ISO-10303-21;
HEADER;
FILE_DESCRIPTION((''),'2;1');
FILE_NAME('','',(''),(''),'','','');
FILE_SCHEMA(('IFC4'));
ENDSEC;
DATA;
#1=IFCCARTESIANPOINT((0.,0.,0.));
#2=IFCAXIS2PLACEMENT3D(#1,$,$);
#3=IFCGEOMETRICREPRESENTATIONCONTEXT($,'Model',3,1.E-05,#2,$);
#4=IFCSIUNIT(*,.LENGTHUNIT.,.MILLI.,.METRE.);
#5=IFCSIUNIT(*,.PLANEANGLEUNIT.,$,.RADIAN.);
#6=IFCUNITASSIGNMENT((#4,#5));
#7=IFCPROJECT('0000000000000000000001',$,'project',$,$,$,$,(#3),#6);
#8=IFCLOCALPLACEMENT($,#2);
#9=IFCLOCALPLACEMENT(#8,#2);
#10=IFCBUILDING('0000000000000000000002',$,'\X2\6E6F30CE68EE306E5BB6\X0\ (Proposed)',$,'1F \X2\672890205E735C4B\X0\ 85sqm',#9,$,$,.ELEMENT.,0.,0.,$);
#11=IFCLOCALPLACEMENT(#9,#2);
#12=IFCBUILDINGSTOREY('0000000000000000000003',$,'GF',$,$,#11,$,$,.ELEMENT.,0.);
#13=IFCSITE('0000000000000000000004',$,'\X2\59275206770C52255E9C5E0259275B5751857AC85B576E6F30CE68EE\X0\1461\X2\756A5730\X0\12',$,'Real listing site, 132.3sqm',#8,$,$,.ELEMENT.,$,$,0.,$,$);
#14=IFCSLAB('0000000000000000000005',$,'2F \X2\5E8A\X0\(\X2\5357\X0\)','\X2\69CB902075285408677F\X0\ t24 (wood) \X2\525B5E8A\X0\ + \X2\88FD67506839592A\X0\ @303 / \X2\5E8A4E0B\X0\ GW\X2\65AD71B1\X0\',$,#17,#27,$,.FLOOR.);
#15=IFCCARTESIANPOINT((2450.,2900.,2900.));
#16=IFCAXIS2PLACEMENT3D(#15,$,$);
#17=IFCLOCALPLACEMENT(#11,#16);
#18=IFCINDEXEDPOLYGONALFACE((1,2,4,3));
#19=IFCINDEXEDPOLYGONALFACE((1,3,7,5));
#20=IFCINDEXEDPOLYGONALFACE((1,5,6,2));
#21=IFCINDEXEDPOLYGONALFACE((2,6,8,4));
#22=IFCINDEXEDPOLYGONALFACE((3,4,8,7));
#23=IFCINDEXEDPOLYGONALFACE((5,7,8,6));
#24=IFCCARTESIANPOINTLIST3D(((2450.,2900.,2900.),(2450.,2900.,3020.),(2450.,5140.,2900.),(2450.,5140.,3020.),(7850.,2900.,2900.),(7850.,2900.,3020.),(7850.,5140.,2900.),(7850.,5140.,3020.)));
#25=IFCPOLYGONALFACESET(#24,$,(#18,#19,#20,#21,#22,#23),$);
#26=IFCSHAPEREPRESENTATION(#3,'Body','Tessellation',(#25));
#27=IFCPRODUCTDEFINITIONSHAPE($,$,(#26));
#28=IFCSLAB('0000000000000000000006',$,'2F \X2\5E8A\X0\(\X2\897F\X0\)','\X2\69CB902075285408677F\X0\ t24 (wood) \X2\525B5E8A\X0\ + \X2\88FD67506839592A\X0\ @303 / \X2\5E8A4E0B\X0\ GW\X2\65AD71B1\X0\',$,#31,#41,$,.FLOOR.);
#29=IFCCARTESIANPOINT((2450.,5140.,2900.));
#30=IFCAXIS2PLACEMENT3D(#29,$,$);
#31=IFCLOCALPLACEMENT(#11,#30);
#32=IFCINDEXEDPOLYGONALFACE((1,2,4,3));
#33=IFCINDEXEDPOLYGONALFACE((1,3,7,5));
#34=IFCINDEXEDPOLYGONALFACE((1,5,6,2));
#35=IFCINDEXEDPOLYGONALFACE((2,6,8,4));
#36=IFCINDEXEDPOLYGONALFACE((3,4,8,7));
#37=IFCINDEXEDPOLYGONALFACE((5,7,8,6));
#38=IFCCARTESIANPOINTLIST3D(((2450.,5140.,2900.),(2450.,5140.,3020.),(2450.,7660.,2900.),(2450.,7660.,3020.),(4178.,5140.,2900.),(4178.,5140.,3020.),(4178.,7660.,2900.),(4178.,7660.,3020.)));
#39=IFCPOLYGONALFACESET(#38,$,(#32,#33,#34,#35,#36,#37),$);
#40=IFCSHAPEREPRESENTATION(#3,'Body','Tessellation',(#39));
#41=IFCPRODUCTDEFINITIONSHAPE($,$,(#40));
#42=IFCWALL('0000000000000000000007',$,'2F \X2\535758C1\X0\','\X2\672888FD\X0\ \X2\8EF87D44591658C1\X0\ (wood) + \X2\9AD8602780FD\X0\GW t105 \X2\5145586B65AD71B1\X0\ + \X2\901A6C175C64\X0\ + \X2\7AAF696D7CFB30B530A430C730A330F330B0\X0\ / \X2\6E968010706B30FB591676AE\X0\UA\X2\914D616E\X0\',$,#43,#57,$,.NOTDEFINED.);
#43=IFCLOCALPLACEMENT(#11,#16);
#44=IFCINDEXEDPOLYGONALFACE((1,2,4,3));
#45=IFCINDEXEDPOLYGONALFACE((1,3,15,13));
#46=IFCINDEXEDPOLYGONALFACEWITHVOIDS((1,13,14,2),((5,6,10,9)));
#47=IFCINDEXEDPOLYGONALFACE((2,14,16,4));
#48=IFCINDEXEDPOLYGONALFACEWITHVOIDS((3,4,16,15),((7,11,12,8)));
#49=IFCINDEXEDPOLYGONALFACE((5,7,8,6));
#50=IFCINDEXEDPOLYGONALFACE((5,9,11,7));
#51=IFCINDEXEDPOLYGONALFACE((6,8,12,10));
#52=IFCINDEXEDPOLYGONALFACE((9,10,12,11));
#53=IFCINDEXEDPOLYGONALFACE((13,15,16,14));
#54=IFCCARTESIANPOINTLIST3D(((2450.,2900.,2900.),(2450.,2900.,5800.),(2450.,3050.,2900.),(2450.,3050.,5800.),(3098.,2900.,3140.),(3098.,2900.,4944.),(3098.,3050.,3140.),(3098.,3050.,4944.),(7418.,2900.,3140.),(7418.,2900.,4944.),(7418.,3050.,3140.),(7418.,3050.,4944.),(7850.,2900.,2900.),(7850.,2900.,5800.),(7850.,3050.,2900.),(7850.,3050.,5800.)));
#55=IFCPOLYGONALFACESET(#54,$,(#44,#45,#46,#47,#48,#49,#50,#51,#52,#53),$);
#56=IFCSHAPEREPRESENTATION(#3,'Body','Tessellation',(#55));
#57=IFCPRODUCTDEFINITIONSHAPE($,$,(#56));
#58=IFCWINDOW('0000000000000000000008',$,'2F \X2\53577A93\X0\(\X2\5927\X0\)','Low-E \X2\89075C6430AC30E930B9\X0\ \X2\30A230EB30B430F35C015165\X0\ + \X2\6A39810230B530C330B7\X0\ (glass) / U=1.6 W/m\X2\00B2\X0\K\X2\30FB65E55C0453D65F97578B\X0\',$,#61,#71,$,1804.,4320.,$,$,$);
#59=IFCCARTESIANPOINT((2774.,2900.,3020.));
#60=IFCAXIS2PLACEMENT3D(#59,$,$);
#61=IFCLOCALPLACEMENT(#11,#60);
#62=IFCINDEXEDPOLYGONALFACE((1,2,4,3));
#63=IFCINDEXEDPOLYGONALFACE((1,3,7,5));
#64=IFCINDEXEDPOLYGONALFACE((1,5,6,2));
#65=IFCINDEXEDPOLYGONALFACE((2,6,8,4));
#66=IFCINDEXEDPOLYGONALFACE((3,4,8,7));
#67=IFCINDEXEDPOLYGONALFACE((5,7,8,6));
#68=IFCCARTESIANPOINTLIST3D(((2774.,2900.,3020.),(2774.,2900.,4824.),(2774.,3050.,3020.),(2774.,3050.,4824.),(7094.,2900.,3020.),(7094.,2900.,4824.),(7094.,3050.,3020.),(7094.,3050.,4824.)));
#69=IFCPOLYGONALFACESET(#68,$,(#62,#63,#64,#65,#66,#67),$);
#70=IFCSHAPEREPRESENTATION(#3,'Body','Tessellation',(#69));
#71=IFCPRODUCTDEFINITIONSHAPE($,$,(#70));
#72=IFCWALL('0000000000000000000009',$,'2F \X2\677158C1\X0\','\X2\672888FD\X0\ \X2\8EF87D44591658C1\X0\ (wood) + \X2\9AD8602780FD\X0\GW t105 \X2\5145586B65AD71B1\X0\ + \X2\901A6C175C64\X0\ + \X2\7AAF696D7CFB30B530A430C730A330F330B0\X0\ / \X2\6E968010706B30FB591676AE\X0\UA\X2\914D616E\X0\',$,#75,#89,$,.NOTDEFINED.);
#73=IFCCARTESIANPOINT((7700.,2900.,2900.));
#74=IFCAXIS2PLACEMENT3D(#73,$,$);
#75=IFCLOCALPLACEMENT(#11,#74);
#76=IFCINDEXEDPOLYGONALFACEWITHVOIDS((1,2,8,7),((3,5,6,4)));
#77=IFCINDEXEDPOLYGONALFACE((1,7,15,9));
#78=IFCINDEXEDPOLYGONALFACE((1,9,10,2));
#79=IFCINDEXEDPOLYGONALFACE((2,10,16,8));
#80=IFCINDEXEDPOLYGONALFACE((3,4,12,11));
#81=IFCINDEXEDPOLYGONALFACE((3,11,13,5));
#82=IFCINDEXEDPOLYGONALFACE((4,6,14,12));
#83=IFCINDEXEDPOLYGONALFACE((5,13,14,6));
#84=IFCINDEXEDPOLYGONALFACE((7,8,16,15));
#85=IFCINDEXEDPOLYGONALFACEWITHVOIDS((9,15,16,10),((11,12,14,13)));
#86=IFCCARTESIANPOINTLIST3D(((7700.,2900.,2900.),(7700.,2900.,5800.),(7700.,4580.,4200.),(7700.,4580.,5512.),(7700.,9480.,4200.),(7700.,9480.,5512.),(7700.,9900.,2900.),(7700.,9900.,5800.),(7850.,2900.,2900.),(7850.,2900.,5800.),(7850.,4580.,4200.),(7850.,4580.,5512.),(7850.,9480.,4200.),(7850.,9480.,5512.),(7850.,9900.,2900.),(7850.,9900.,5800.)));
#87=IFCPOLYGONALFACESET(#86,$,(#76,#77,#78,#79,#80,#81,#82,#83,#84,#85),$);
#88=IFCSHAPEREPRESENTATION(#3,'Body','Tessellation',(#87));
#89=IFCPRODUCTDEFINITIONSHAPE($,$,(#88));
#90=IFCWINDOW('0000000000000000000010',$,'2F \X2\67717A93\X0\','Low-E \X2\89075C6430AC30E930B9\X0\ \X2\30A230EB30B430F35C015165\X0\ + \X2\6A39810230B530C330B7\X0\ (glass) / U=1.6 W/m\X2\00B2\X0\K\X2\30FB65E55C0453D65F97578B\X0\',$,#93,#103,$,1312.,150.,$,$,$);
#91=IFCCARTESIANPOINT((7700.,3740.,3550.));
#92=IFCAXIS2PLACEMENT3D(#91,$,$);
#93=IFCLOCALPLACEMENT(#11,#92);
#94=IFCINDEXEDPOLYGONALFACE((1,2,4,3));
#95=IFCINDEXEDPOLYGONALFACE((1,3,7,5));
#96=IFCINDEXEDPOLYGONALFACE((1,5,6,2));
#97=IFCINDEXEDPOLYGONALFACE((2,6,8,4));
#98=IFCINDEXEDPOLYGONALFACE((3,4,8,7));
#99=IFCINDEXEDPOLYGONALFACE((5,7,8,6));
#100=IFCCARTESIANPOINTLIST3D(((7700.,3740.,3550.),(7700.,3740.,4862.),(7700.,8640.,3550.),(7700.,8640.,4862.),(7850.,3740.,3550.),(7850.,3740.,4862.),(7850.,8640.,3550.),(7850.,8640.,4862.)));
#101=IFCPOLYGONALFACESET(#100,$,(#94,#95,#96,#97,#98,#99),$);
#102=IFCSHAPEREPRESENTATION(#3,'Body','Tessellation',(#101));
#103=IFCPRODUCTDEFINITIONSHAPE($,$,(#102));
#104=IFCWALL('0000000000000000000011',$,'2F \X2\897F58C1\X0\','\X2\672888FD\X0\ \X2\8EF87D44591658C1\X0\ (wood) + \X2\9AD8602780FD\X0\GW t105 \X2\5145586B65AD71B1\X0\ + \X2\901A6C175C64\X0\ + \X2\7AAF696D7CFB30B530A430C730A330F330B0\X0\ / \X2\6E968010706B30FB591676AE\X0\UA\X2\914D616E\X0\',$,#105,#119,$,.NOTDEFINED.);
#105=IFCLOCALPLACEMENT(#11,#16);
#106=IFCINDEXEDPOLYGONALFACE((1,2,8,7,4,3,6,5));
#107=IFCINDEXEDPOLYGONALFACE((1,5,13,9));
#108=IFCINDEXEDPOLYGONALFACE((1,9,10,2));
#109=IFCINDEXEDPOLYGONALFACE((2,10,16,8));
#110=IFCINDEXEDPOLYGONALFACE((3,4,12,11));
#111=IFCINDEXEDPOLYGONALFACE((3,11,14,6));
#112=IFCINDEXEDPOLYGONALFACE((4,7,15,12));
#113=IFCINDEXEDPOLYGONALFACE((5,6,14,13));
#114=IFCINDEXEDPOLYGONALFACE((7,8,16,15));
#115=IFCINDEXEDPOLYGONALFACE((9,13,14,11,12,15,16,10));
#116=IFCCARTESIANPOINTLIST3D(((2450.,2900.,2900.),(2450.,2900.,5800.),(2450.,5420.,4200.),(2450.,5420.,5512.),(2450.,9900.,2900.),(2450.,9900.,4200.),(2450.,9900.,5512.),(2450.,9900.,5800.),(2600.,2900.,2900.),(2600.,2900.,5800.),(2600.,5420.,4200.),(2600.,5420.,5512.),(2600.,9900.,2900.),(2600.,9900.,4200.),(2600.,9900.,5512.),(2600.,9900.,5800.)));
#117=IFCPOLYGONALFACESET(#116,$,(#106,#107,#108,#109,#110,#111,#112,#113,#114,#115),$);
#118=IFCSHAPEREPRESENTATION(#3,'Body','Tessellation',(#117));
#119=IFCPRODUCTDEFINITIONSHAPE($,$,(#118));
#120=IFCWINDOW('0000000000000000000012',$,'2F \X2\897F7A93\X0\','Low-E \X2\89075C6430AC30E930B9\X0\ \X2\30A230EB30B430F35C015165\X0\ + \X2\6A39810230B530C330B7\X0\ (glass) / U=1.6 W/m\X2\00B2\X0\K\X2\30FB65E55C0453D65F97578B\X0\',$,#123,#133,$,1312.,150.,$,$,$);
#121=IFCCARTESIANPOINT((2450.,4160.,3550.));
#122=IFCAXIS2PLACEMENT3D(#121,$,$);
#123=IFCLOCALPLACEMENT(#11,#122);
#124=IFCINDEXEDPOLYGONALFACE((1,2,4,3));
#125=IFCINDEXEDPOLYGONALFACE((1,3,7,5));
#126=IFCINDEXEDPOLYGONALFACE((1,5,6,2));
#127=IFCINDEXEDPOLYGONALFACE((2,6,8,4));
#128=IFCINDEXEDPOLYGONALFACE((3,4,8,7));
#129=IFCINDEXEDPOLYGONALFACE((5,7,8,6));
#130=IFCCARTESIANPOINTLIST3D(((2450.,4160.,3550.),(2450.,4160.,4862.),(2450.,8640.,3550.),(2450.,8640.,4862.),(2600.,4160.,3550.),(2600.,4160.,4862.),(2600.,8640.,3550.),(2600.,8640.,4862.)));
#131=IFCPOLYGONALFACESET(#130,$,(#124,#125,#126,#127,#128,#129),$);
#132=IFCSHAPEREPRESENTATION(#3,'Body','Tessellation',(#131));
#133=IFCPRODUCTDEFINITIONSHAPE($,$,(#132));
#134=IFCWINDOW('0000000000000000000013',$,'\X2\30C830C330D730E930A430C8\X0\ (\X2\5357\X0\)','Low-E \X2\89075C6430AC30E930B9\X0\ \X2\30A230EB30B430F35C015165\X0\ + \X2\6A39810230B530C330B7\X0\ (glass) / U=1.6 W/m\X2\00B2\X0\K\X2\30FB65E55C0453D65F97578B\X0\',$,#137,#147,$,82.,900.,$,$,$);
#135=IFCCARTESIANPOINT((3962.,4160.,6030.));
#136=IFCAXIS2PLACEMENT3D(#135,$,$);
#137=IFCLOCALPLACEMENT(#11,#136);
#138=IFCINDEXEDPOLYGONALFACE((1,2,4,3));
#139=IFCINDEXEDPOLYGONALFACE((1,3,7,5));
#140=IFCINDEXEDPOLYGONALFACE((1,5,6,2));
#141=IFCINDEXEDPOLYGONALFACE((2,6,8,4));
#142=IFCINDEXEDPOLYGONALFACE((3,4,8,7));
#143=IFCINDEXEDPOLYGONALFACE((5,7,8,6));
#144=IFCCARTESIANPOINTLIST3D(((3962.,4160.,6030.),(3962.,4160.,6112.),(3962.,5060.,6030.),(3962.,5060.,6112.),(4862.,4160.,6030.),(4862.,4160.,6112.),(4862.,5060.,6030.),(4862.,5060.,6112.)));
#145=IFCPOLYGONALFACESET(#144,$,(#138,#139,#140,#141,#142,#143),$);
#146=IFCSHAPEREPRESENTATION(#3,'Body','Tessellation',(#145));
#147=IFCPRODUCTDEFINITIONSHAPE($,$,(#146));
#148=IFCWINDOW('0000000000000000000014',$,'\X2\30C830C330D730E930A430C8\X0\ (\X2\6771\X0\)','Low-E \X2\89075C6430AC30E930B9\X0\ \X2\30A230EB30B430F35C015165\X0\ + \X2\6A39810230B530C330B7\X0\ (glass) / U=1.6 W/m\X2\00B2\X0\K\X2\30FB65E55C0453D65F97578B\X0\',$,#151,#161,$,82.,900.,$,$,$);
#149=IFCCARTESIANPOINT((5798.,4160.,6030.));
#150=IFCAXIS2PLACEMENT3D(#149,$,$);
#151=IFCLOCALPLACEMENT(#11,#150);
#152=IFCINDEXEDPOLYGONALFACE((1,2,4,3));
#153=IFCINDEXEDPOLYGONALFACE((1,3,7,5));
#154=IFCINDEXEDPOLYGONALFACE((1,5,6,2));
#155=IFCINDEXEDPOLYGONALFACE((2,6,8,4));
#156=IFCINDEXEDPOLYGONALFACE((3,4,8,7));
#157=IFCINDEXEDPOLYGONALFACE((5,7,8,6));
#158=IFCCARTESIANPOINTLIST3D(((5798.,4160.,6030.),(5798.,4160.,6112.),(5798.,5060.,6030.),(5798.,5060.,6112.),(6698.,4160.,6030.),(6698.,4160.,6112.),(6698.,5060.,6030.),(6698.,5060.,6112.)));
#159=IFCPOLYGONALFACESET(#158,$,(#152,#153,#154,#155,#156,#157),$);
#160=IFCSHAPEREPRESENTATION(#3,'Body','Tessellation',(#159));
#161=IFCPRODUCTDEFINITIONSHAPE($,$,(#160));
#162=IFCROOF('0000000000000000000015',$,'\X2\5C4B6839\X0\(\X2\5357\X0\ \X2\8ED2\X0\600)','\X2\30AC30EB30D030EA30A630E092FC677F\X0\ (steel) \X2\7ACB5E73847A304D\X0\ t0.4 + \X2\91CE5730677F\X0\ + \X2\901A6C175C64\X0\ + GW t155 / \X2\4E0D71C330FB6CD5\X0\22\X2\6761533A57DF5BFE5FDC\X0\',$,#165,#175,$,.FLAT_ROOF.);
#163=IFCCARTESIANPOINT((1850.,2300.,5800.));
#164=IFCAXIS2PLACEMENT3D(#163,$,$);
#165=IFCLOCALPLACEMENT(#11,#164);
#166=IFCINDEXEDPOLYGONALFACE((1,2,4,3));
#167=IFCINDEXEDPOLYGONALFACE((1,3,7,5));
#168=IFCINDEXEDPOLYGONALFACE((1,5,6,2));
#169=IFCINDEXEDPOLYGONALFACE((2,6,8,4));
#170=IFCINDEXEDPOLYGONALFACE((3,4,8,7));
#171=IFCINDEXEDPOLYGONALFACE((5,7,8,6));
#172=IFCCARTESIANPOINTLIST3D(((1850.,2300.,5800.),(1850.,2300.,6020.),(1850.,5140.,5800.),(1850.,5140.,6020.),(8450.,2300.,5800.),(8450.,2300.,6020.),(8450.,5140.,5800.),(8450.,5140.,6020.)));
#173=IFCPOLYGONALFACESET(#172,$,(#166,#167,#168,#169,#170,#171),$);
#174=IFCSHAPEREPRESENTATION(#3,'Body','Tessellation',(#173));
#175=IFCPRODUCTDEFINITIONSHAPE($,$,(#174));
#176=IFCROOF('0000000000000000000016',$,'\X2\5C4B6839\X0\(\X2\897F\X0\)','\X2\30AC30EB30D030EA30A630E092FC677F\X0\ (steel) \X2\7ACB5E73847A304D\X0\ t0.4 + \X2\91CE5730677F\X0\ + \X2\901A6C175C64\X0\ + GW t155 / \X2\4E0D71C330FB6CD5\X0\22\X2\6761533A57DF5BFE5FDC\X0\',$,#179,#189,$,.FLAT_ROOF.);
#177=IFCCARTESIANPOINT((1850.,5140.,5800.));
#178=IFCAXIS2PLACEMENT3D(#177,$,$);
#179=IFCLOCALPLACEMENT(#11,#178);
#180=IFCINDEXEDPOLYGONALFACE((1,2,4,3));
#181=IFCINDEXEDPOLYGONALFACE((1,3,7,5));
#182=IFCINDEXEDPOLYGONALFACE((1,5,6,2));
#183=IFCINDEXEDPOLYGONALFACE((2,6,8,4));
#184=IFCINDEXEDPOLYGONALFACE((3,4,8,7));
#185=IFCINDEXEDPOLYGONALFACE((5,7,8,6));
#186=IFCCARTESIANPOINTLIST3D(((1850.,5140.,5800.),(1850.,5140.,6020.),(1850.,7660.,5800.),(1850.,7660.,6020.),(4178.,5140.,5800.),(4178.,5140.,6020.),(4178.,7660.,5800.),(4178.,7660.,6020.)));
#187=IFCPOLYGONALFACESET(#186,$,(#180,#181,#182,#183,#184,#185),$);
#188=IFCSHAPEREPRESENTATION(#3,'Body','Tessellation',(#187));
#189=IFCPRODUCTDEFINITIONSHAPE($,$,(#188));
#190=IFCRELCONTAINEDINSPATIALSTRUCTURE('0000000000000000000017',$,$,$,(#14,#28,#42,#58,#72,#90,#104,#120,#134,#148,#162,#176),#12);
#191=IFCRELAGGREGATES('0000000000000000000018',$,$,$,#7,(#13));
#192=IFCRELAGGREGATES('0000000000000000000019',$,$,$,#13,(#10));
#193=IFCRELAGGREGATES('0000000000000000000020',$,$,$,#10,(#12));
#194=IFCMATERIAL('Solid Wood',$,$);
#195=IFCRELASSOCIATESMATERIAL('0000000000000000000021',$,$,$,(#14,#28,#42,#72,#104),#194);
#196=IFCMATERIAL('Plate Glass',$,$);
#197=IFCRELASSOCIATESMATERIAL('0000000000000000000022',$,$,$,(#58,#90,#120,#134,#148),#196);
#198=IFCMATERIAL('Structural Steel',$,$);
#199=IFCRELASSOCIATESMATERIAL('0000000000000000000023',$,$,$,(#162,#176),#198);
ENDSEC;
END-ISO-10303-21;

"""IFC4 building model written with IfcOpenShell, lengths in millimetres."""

from ifc_helpers import new_model, si_unit, frame, frame_2d, origin, place, context, project, spatial, rectangle, extrude, material, element, fill, save


model = new_model("IFC4")

# Units and contexts
model_context = context("Model", 3, precision=1e-05, world=origin())
ifc_project = project(units=[si_unit("LENGTHUNIT", "METRE", prefix="MILLI"), si_unit("PLANEANGLEUNIT", "RADIAN")], contexts=[model_context])

# Site, building, storey
site_placement = place(None, origin())
site = spatial("IfcSite", under=ifc_project, at=site_placement, Name="大分県別府市大字内竈字湯ノ森1461番地12", ObjectType="Real listing site, 132.3sqm", CompositionType="ELEMENT", RefElevation=0.0)
building_placement = place(site_placement, origin())
building = spatial("IfcBuilding", under=site, at=building_placement, Name="湯ノ森の家 (Proposed)", ObjectType="1F 木造平屋 85sqm", CompositionType="ELEMENT", ElevationOfRefHeight=0.0, ElevationOfTerrain=0.0)
storey_placement = place(building_placement, origin())
storey = spatial("IfcBuildingStorey", under=building, at=storey_placement, Name="GF", CompositionType="ELEMENT", Elevation=0.0)

# Slabs
ifc_material_1 = material(Name="Solid Wood")
slab_1_placement = place(storey_placement, frame((2450.0, 2900.0, 2900.0)))
element("IfcSlab", 1, at=slab_1_placement, inside=storey, material=ifc_material_1, Name="2F 床(南)", Description="構造用合板 t24 (wood) 剛床 + 製材根太 @303 / 床下 GW断熱", PredefinedType="FLOOR", context=model_context, shape_type="SweptSolid", body=[
    extrude(rectangle(XDim=5400.0, YDim=2240.0, at=frame_2d((2700.0, 1120.0))), frame((2450.0, 2900.0, 2900.0)), (0.0, 0.0, 1.0), 120.0),
])
slab_2_placement = place(storey_placement, frame((2450.0, 5140.0, 2900.0)))
element("IfcSlab", 2, at=slab_2_placement, inside=storey, material=ifc_material_1, Name="2F 床(西)", Description="構造用合板 t24 (wood) 剛床 + 製材根太 @303 / 床下 GW断熱", PredefinedType="FLOOR", context=model_context, shape_type="SweptSolid", body=[
    extrude(rectangle(XDim=1728.0, YDim=2520.0, at=frame_2d((864.0, 1260.0))), frame((2450.0, 5140.0, 2900.0)), (0.0, 0.0, 1.0), 120.0),
])

# Walls, openings, windows
wall_1_placement = place(storey_placement, frame((2450.0, 2900.0, 2900.0)))
wall_1 = element("IfcWall", 3, at=wall_1_placement, inside=storey, material=ifc_material_1, Name="2F 南壁", Description="木製 軸組外壁 (wood) + 高性能GW t105 充填断熱 + 通気層 + 窯業系サイディング / 準耐火・外皮UA配慮", PredefinedType="NOTDEFINED", context=model_context, shape_type="SweptSolid", body=[
    extrude(rectangle(XDim=5400.0, YDim=150.0, at=frame_2d((2700.0, 75.0))), frame((2450.0, 2900.0, 2900.0)), (0.0, 0.0, 1.0), 2900.0),
])
opening_1_placement = place(storey_placement, frame((2774.0, 2900.0, 3020.0)))
opening_1 = element("IfcOpeningElement", 4, at=opening_1_placement, cuts=wall_1, PredefinedType="NOTDEFINED", context=model_context, shape_type="SweptSolid", body=[
    extrude(rectangle(XDim=4320.0, YDim=150.0, at=frame_2d((2160.0, 75.0))), frame((2774.0, 2900.0, 3020.0)), (0.0, 0.0, 1.0), 1804.0),
])
ifc_material_2 = material(Name="Plate Glass")
window_1_placement = place(storey_placement, frame((2774.0, 2900.0, 3020.0)))
window_1 = element("IfcWindow", 5, at=window_1_placement, inside=storey, material=ifc_material_2, Name="2F 南窓(大)", Description="Low-E 複層ガラス アルゴン封入 + 樹脂サッシ (glass) / U=1.6 W/m²K・日射取得型", OverallHeight=1804.0, OverallWidth=4320.0, context=model_context, shape_type="SweptSolid", body=[
    extrude(rectangle(XDim=4320.0, YDim=150.0, at=frame_2d((2160.0, 75.0))), frame((2774.0, 2900.0, 3020.0)), (0.0, 0.0, 1.0), 1804.0),
])
fill(opening_1, window_1)
wall_2_placement = place(storey_placement, frame((7700.0, 2900.0, 2900.0)))
wall_2 = element("IfcWall", 6, at=wall_2_placement, inside=storey, material=ifc_material_1, Name="2F 東壁", Description="木製 軸組外壁 (wood) + 高性能GW t105 充填断熱 + 通気層 + 窯業系サイディング / 準耐火・外皮UA配慮", PredefinedType="NOTDEFINED", context=model_context, shape_type="SweptSolid", body=[
    extrude(rectangle(XDim=150.0, YDim=7000.0, at=frame_2d((75.0, 3500.0))), frame((7700.0, 2900.0, 2900.0)), (0.0, 0.0, 1.0), 2900.0),
])
opening_2_placement = place(storey_placement, frame((7700.0, 3740.0, 3550.0)))
opening_2 = element("IfcOpeningElement", 7, at=opening_2_placement, cuts=wall_2, PredefinedType="NOTDEFINED", context=model_context, shape_type="SweptSolid", body=[
    extrude(rectangle(XDim=150.0, YDim=4900.0, at=frame_2d((75.0, 2450.0))), frame((7700.0, 3740.0, 3550.0)), (0.0, 0.0, 1.0), 1312.0),
])
window_2_placement = place(storey_placement, frame((7700.0, 3740.0, 3550.0)))
window_2 = element("IfcWindow", 8, at=window_2_placement, inside=storey, material=ifc_material_2, Name="2F 東窓", Description="Low-E 複層ガラス アルゴン封入 + 樹脂サッシ (glass) / U=1.6 W/m²K・日射取得型", OverallHeight=1312.0, OverallWidth=150.0, context=model_context, shape_type="SweptSolid", body=[
    extrude(rectangle(XDim=150.0, YDim=4900.0, at=frame_2d((75.0, 2450.0))), frame((7700.0, 3740.0, 3550.0)), (0.0, 0.0, 1.0), 1312.0),
])
fill(opening_2, window_2)
wall_3_placement = place(storey_placement, frame((2450.0, 2900.0, 2900.0)))
wall_3 = element("IfcWall", 9, at=wall_3_placement, inside=storey, material=ifc_material_1, Name="2F 西壁", Description="木製 軸組外壁 (wood) + 高性能GW t105 充填断熱 + 通気層 + 窯業系サイディング / 準耐火・外皮UA配慮", PredefinedType="NOTDEFINED", context=model_context, shape_type="SweptSolid", body=[
    extrude(rectangle(XDim=150.0, YDim=7000.0, at=frame_2d((75.0, 3500.0))), frame((2450.0, 2900.0, 2900.0)), (0.0, 0.0, 1.0), 2900.0),
])
opening_3_placement = place(storey_placement, frame((2450.0, 4160.0, 3550.0)))
opening_3 = element("IfcOpeningElement", 10, at=opening_3_placement, cuts=wall_3, PredefinedType="NOTDEFINED", context=model_context, shape_type="SweptSolid", body=[
    extrude(rectangle(XDim=150.0, YDim=4480.0, at=frame_2d((75.0, 2240.0))), frame((2450.0, 4160.0, 3550.0)), (0.0, 0.0, 1.0), 1312.0),
])
window_3_placement = place(storey_placement, frame((2450.0, 4160.0, 3550.0)))
window_3 = element("IfcWindow", 11, at=window_3_placement, inside=storey, material=ifc_material_2, Name="2F 西窓", Description="Low-E 複層ガラス アルゴン封入 + 樹脂サッシ (glass) / U=1.6 W/m²K・日射取得型", OverallHeight=1312.0, OverallWidth=150.0, context=model_context, shape_type="SweptSolid", body=[
    extrude(rectangle(XDim=150.0, YDim=4480.0, at=frame_2d((75.0, 2240.0))), frame((2450.0, 4160.0, 3550.0)), (0.0, 0.0, 1.0), 1312.0),
])
fill(opening_3, window_3)

# Windows
window_4_placement = place(storey_placement, frame((3962.0, 4160.0, 6030.0)))
element("IfcWindow", 12, at=window_4_placement, inside=storey, material=ifc_material_2, Name="トップライト (南)", Description="Low-E 複層ガラス アルゴン封入 + 樹脂サッシ (glass) / U=1.6 W/m²K・日射取得型", OverallHeight=82.0, OverallWidth=900.0, context=model_context, shape_type="SweptSolid", body=[
    extrude(rectangle(XDim=900.0, YDim=900.0, at=frame_2d((450.0, 450.0))), frame((3962.0, 4160.0, 6030.0)), (0.0, 0.0, 1.0), 82.0),
])
window_5_placement = place(storey_placement, frame((5798.0, 4160.0, 6030.0)))
element("IfcWindow", 13, at=window_5_placement, inside=storey, material=ifc_material_2, Name="トップライト (東)", Description="Low-E 複層ガラス アルゴン封入 + 樹脂サッシ (glass) / U=1.6 W/m²K・日射取得型", OverallHeight=82.0, OverallWidth=900.0, context=model_context, shape_type="SweptSolid", body=[
    extrude(rectangle(XDim=900.0, YDim=900.0, at=frame_2d((450.0, 450.0))), frame((5798.0, 4160.0, 6030.0)), (0.0, 0.0, 1.0), 82.0),
])

# Roofs
ifc_material_3 = material(Name="Structural Steel")
roof_1_placement = place(storey_placement, frame((1850.0, 2300.0, 5800.0)))
element("IfcRoof", 14, at=roof_1_placement, inside=storey, material=ifc_material_3, Name="屋根(南 軒600)", Description="ガルバリウム鋼板 (steel) 立平葺き t0.4 + 野地板 + 通気層 + GW t155 / 不燃・法22条区域対応", PredefinedType="FLAT_ROOF", context=model_context, shape_type="SweptSolid", body=[
    extrude(rectangle(XDim=6600.0, YDim=2840.0, at=frame_2d((3300.0, 1420.0))), frame((1850.0, 2300.0, 5800.0)), (0.0, 0.0, 1.0), 220.0),
])
roof_2_placement = place(storey_placement, frame((1850.0, 5140.0, 5800.0)))
element("IfcRoof", 15, at=roof_2_placement, inside=storey, material=ifc_material_3, Name="屋根(西)", Description="ガルバリウム鋼板 (steel) 立平葺き t0.4 + 野地板 + 通気層 + GW t155 / 不燃・法22条区域対応", PredefinedType="FLAT_ROOF", context=model_context, shape_type="SweptSolid", body=[
    extrude(rectangle(XDim=2328.0, YDim=2520.0, at=frame_2d((1164.0, 1260.0))), frame((1850.0, 5140.0, 5800.0)), (0.0, 0.0, 1.0), 220.0),
])

save(model, "model.ifc")
